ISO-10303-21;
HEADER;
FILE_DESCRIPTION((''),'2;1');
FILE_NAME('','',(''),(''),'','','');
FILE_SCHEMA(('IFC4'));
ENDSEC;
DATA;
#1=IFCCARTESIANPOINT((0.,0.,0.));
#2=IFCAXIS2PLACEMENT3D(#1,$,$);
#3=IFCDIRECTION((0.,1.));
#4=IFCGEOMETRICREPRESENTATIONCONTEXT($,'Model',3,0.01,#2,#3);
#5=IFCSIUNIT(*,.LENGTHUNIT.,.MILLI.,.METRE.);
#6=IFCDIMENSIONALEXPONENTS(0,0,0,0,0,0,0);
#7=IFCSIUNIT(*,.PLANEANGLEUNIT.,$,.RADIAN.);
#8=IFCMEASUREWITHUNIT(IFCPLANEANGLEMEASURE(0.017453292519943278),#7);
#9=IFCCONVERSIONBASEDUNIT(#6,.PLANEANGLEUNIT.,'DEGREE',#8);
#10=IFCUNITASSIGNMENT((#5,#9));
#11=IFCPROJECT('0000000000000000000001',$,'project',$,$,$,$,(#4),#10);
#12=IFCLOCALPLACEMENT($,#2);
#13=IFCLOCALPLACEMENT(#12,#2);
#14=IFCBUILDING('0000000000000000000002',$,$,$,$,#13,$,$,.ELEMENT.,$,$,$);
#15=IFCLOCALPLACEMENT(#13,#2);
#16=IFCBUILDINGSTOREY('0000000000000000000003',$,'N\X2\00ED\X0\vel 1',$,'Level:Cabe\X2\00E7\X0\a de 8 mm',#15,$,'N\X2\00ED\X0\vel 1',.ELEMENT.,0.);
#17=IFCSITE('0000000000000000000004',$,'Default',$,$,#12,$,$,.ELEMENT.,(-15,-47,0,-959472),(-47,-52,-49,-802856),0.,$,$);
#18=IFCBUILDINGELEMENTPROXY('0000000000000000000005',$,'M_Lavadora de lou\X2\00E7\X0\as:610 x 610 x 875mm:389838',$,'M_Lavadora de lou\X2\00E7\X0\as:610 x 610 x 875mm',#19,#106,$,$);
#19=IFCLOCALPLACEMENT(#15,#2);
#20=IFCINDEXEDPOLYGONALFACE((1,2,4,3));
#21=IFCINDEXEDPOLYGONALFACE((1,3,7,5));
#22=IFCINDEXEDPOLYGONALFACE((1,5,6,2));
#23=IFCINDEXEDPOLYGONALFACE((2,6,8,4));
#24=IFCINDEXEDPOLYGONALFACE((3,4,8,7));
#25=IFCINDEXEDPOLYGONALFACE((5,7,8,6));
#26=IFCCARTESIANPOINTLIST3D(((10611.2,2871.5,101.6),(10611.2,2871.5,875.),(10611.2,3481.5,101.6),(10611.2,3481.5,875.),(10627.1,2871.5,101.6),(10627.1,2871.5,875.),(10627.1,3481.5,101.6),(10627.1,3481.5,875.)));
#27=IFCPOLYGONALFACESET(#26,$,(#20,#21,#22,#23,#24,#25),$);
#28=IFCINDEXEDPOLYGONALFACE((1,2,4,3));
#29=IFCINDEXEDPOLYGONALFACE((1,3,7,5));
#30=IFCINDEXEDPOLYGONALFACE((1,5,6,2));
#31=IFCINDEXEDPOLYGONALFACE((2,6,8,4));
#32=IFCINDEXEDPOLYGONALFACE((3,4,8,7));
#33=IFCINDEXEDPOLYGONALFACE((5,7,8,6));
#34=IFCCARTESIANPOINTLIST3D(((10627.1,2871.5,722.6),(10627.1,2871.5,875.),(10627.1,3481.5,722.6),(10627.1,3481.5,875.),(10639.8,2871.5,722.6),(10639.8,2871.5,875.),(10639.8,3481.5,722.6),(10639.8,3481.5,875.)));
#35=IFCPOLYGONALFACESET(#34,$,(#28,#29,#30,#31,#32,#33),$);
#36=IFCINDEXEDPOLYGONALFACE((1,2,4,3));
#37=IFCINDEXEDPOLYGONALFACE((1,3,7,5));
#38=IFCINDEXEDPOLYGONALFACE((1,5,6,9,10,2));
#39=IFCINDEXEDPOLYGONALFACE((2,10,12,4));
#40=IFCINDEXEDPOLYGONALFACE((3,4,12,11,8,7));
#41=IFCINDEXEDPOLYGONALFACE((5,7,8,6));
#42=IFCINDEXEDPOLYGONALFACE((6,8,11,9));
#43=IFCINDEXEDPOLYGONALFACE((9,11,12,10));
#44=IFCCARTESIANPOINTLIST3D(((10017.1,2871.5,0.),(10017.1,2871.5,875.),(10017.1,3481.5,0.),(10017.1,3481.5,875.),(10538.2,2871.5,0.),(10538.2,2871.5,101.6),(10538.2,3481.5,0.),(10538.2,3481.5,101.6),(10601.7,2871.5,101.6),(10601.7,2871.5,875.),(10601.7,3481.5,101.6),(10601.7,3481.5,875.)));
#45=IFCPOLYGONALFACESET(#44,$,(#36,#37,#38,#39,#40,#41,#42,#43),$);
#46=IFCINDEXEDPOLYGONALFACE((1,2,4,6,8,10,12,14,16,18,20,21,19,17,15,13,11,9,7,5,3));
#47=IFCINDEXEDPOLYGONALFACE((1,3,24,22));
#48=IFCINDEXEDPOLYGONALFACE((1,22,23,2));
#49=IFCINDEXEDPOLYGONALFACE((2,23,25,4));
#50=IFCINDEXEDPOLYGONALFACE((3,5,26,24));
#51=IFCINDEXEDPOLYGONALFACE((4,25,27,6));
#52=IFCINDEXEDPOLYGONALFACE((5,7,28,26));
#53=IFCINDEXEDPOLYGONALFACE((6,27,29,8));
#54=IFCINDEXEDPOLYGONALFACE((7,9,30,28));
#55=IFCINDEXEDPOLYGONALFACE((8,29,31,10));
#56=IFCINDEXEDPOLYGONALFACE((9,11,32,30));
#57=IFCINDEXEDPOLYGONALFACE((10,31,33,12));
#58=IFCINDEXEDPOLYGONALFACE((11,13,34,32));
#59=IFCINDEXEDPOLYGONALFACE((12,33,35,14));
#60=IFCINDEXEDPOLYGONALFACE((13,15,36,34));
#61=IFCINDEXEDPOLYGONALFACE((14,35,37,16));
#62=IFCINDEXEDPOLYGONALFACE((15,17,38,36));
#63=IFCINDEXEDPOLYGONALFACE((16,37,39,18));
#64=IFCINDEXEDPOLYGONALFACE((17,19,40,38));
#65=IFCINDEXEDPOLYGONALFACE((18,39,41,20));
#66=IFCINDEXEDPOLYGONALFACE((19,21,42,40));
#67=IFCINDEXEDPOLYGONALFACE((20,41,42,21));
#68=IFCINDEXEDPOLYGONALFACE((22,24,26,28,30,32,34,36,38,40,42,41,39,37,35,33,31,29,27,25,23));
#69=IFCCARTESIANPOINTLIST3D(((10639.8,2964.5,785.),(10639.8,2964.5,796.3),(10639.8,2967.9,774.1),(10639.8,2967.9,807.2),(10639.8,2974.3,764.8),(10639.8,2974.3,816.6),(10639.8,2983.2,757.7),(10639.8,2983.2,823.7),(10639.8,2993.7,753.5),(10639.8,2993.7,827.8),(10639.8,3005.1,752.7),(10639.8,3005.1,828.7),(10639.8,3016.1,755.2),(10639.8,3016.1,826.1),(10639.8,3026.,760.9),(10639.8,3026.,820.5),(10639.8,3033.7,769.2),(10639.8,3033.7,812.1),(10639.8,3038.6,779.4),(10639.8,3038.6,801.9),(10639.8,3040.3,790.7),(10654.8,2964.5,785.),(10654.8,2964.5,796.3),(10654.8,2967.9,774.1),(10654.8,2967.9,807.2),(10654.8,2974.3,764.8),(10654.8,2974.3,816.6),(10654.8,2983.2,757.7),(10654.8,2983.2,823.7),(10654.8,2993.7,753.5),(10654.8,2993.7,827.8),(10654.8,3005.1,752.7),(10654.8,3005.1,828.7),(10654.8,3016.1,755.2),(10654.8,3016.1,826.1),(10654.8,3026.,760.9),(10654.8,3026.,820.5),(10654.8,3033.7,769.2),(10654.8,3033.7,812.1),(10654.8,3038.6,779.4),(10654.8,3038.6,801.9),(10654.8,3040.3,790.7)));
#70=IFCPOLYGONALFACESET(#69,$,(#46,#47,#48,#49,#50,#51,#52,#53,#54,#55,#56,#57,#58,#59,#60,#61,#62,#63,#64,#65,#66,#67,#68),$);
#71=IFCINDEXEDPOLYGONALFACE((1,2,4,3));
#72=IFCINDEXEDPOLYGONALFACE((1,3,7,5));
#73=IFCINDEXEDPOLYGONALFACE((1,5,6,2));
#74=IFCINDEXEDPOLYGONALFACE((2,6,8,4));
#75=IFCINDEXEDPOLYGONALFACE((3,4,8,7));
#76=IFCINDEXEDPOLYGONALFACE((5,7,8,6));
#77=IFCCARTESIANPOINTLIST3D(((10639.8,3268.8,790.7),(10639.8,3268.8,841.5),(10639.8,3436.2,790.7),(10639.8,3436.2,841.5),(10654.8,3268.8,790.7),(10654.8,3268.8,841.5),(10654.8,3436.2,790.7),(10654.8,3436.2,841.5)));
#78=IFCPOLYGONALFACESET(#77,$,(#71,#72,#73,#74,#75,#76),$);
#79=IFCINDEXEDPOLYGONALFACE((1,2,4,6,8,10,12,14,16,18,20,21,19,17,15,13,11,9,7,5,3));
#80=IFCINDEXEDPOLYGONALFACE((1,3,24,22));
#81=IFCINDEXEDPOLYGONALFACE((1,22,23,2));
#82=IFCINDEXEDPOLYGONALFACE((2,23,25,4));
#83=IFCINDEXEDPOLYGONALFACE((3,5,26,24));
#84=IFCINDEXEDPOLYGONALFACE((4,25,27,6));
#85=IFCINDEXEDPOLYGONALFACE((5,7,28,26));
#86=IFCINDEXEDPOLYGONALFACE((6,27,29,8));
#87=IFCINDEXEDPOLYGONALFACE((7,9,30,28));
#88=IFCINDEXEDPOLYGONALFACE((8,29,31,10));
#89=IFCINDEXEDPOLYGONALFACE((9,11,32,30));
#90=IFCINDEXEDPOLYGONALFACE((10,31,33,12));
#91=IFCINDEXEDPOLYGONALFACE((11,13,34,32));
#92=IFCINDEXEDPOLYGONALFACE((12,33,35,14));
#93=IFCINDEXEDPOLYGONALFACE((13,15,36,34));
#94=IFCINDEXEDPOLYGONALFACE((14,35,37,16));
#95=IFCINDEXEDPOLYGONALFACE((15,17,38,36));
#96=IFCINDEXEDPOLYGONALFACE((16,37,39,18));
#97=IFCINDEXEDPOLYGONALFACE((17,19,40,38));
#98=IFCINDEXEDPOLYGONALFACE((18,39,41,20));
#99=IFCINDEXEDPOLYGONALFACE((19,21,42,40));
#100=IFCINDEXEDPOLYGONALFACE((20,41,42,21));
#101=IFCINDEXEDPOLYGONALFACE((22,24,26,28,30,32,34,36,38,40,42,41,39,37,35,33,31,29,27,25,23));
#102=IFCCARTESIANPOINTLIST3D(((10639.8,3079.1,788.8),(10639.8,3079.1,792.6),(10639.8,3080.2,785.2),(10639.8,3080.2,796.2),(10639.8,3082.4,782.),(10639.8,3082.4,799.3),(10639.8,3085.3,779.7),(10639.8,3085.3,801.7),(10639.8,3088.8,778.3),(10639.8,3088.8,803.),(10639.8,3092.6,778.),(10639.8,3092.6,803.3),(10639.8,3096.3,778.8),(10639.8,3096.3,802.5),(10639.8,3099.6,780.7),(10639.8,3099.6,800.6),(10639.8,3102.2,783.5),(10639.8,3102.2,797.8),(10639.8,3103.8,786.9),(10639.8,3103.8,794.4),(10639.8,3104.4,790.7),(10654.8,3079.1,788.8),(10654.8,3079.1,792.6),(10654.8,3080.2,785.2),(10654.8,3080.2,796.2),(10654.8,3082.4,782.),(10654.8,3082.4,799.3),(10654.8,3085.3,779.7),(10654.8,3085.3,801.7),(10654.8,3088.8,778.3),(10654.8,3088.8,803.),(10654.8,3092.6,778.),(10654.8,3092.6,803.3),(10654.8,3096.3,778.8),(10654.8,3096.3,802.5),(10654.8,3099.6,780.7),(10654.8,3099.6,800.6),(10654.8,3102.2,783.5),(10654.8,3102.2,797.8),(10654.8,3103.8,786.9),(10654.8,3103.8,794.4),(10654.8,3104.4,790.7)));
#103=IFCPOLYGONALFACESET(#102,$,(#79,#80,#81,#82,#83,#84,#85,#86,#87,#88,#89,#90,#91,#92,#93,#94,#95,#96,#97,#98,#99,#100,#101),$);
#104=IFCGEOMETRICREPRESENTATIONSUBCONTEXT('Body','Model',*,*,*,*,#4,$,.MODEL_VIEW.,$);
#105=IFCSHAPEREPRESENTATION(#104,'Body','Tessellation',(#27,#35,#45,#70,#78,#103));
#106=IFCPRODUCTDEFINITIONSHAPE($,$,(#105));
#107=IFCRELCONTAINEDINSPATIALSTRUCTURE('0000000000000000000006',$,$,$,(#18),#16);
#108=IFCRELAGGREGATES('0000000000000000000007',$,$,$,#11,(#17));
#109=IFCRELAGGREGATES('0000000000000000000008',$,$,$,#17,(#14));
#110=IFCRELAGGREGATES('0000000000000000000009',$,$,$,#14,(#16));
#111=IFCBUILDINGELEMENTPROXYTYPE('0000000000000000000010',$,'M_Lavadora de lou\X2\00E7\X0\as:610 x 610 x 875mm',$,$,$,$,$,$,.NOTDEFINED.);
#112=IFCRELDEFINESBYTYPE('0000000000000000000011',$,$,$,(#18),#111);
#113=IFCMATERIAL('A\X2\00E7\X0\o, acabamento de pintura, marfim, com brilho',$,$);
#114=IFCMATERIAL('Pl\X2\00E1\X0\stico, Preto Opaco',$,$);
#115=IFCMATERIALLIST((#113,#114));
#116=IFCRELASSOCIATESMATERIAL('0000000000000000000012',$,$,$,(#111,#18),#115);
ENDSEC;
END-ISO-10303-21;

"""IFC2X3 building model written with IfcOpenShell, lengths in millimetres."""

from ifc_helpers import new_model, entity, si_unit, converted_unit, direction, frame, frame_2d, origin, place, context, subcontext, project, spatial, polyline, rectangle, circle, outline, extrude, source, transform, mapped, material, material_list, type_object, type_shapes, element, save


model = new_model("IFC2X3")

# Units and contexts
model_context = context("Model", 3, precision=0.01, world=origin(), true_north=direction((0.0, 1.0)))
body_context = subcontext(model_context, "Body", "Model", "MODEL_VIEW")
ifc_project = project(units=[si_unit("LENGTHUNIT", "METRE", prefix="MILLI"), converted_unit("PLANEANGLEUNIT", "DEGREE", entity("IfcPlaneAngleMeasure", 0.017453292519943278), si_unit("PLANEANGLEUNIT", "RADIAN"), dimensions=[0, 0, 0, 0, 0, 0, 0])], contexts=[model_context])

# Site, building, storey
site_placement = place(None, origin())
site = spatial("IfcSite", under=ifc_project, at=site_placement, Name="Default", CompositionType="ELEMENT", RefLatitude=(-15, -47, 0, -959472), RefLongitude=(-47, -52, -49, -802856), RefElevation=0.0)
building_placement = place(site_placement, origin())
building = spatial("IfcBuilding", under=site, at=building_placement, CompositionType="ELEMENT")
storey_placement = place(building_placement, origin())
storey = spatial("IfcBuildingStorey", under=building, at=storey_placement, Name="Nível 1", ObjectType="Level:Cabeça de 8 mm", LongName="Nível 1", CompositionType="ELEMENT", Elevation=0.0)

# Building element proxy
ifc_material_1 = material(Name="Aço, acabamento de pintura, marfim, com brilho")
ifc_material_2 = material(Name="Plástico, Preto Opaco")
ifc_material_list_1 = material_list([ifc_material_1, ifc_material_2])
building_element_proxy_type_1 = type_object("IfcBuildingElementProxyType", Name="M_Lavadora de louças:610 x 610 x 875mm", PredefinedType="NOTDEFINED", material=ifc_material_list_1)
shared_shape_1 = source(origin(), body_context, "Body", "SweptSolid", [
    extrude(rectangle(XDim=610.0, YDim=15.9, at=frame_2d((0.0, 0.0), x_axis=(1.0, 0.0))), frame((382.5, 30.4, 101.6), z_axis=(0.0, 0.0, 1.0), x_axis=(-1.0, 0.0, 0.0)), (0.0, 0.0, 1.0), 773.4),
    extrude(rectangle(XDim=12.7, YDim=610.0, at=frame_2d((0.0, 0.0), x_axis=(1.0, 0.0))), frame((382.5, 44.7, 722.6), z_axis=(0.0, 0.0, 1.0), x_axis=(0.0, 1.0, 0.0)), (0.0, 0.0, 1.0), 152.4),
    extrude(outline(polyline([(-368.6, -325.5), (152.5, -325.5), (152.5, -223.9), (216.0, -223.9), (216.0, 549.5), (-368.6, 549.5), (-368.6, -325.5)])), frame((77.5, -203.1, 325.5), z_axis=(1.0, 0.0, 0.0), x_axis=(0.0, 1.0, 0.0)), (0.0, 0.0, 1.0), 610.0),
    extrude(circle(Radius=38.1, at=frame_2d((0.0, 0.0), x_axis=(1.0, 0.0))), frame((556.8, 51.1, 790.7), z_axis=(0.0, 1.0, 0.0), x_axis=(-1.0, 0.0, 0.0)), (0.0, 0.0, 1.0), 15.0),
    extrude(rectangle(XDim=167.4, YDim=15.0, at=frame_2d((0.0, 0.0), x_axis=(1.0, 0.0))), frame((206.5, 58.6, 790.7), z_axis=(0.0, 0.0, 1.0), x_axis=(-1.0, 0.0, 0.0)), (0.0, 0.0, 1.0), 50.8),
    extrude(circle(Radius=12.7, at=frame_2d((0.0, 0.0), x_axis=(1.0, 0.0))), frame((467.3, 51.1, 790.7), z_axis=(0.0, 1.0, 0.0), x_axis=(-1.0, 0.0, 0.0)), (0.0, 0.0, 1.0), 15.0),
])
type_shapes(building_element_proxy_type_1, [shared_shape_1])
proxy_1_placement = place(storey_placement, frame((10588.7, 3559.0, 0.0), z_axis=(0.0, 0.0, 1.0), x_axis=(0.0, -1.0, 0.0)))
element("IfcBuildingElementProxy", 1, at=proxy_1_placement, inside=storey, type_object=building_element_proxy_type_1, material=ifc_material_list_1, Name="M_Lavadora de louças:610 x 610 x 875mm:389838", ObjectType="M_Lavadora de louças:610 x 610 x 875mm", context=body_context, shape_type="MappedRepresentation", body=[
    mapped(shared_shape_1, transform((0.0, 0.0, 0.0), scale=1.0)),
])

save(model, "model.ifc")
